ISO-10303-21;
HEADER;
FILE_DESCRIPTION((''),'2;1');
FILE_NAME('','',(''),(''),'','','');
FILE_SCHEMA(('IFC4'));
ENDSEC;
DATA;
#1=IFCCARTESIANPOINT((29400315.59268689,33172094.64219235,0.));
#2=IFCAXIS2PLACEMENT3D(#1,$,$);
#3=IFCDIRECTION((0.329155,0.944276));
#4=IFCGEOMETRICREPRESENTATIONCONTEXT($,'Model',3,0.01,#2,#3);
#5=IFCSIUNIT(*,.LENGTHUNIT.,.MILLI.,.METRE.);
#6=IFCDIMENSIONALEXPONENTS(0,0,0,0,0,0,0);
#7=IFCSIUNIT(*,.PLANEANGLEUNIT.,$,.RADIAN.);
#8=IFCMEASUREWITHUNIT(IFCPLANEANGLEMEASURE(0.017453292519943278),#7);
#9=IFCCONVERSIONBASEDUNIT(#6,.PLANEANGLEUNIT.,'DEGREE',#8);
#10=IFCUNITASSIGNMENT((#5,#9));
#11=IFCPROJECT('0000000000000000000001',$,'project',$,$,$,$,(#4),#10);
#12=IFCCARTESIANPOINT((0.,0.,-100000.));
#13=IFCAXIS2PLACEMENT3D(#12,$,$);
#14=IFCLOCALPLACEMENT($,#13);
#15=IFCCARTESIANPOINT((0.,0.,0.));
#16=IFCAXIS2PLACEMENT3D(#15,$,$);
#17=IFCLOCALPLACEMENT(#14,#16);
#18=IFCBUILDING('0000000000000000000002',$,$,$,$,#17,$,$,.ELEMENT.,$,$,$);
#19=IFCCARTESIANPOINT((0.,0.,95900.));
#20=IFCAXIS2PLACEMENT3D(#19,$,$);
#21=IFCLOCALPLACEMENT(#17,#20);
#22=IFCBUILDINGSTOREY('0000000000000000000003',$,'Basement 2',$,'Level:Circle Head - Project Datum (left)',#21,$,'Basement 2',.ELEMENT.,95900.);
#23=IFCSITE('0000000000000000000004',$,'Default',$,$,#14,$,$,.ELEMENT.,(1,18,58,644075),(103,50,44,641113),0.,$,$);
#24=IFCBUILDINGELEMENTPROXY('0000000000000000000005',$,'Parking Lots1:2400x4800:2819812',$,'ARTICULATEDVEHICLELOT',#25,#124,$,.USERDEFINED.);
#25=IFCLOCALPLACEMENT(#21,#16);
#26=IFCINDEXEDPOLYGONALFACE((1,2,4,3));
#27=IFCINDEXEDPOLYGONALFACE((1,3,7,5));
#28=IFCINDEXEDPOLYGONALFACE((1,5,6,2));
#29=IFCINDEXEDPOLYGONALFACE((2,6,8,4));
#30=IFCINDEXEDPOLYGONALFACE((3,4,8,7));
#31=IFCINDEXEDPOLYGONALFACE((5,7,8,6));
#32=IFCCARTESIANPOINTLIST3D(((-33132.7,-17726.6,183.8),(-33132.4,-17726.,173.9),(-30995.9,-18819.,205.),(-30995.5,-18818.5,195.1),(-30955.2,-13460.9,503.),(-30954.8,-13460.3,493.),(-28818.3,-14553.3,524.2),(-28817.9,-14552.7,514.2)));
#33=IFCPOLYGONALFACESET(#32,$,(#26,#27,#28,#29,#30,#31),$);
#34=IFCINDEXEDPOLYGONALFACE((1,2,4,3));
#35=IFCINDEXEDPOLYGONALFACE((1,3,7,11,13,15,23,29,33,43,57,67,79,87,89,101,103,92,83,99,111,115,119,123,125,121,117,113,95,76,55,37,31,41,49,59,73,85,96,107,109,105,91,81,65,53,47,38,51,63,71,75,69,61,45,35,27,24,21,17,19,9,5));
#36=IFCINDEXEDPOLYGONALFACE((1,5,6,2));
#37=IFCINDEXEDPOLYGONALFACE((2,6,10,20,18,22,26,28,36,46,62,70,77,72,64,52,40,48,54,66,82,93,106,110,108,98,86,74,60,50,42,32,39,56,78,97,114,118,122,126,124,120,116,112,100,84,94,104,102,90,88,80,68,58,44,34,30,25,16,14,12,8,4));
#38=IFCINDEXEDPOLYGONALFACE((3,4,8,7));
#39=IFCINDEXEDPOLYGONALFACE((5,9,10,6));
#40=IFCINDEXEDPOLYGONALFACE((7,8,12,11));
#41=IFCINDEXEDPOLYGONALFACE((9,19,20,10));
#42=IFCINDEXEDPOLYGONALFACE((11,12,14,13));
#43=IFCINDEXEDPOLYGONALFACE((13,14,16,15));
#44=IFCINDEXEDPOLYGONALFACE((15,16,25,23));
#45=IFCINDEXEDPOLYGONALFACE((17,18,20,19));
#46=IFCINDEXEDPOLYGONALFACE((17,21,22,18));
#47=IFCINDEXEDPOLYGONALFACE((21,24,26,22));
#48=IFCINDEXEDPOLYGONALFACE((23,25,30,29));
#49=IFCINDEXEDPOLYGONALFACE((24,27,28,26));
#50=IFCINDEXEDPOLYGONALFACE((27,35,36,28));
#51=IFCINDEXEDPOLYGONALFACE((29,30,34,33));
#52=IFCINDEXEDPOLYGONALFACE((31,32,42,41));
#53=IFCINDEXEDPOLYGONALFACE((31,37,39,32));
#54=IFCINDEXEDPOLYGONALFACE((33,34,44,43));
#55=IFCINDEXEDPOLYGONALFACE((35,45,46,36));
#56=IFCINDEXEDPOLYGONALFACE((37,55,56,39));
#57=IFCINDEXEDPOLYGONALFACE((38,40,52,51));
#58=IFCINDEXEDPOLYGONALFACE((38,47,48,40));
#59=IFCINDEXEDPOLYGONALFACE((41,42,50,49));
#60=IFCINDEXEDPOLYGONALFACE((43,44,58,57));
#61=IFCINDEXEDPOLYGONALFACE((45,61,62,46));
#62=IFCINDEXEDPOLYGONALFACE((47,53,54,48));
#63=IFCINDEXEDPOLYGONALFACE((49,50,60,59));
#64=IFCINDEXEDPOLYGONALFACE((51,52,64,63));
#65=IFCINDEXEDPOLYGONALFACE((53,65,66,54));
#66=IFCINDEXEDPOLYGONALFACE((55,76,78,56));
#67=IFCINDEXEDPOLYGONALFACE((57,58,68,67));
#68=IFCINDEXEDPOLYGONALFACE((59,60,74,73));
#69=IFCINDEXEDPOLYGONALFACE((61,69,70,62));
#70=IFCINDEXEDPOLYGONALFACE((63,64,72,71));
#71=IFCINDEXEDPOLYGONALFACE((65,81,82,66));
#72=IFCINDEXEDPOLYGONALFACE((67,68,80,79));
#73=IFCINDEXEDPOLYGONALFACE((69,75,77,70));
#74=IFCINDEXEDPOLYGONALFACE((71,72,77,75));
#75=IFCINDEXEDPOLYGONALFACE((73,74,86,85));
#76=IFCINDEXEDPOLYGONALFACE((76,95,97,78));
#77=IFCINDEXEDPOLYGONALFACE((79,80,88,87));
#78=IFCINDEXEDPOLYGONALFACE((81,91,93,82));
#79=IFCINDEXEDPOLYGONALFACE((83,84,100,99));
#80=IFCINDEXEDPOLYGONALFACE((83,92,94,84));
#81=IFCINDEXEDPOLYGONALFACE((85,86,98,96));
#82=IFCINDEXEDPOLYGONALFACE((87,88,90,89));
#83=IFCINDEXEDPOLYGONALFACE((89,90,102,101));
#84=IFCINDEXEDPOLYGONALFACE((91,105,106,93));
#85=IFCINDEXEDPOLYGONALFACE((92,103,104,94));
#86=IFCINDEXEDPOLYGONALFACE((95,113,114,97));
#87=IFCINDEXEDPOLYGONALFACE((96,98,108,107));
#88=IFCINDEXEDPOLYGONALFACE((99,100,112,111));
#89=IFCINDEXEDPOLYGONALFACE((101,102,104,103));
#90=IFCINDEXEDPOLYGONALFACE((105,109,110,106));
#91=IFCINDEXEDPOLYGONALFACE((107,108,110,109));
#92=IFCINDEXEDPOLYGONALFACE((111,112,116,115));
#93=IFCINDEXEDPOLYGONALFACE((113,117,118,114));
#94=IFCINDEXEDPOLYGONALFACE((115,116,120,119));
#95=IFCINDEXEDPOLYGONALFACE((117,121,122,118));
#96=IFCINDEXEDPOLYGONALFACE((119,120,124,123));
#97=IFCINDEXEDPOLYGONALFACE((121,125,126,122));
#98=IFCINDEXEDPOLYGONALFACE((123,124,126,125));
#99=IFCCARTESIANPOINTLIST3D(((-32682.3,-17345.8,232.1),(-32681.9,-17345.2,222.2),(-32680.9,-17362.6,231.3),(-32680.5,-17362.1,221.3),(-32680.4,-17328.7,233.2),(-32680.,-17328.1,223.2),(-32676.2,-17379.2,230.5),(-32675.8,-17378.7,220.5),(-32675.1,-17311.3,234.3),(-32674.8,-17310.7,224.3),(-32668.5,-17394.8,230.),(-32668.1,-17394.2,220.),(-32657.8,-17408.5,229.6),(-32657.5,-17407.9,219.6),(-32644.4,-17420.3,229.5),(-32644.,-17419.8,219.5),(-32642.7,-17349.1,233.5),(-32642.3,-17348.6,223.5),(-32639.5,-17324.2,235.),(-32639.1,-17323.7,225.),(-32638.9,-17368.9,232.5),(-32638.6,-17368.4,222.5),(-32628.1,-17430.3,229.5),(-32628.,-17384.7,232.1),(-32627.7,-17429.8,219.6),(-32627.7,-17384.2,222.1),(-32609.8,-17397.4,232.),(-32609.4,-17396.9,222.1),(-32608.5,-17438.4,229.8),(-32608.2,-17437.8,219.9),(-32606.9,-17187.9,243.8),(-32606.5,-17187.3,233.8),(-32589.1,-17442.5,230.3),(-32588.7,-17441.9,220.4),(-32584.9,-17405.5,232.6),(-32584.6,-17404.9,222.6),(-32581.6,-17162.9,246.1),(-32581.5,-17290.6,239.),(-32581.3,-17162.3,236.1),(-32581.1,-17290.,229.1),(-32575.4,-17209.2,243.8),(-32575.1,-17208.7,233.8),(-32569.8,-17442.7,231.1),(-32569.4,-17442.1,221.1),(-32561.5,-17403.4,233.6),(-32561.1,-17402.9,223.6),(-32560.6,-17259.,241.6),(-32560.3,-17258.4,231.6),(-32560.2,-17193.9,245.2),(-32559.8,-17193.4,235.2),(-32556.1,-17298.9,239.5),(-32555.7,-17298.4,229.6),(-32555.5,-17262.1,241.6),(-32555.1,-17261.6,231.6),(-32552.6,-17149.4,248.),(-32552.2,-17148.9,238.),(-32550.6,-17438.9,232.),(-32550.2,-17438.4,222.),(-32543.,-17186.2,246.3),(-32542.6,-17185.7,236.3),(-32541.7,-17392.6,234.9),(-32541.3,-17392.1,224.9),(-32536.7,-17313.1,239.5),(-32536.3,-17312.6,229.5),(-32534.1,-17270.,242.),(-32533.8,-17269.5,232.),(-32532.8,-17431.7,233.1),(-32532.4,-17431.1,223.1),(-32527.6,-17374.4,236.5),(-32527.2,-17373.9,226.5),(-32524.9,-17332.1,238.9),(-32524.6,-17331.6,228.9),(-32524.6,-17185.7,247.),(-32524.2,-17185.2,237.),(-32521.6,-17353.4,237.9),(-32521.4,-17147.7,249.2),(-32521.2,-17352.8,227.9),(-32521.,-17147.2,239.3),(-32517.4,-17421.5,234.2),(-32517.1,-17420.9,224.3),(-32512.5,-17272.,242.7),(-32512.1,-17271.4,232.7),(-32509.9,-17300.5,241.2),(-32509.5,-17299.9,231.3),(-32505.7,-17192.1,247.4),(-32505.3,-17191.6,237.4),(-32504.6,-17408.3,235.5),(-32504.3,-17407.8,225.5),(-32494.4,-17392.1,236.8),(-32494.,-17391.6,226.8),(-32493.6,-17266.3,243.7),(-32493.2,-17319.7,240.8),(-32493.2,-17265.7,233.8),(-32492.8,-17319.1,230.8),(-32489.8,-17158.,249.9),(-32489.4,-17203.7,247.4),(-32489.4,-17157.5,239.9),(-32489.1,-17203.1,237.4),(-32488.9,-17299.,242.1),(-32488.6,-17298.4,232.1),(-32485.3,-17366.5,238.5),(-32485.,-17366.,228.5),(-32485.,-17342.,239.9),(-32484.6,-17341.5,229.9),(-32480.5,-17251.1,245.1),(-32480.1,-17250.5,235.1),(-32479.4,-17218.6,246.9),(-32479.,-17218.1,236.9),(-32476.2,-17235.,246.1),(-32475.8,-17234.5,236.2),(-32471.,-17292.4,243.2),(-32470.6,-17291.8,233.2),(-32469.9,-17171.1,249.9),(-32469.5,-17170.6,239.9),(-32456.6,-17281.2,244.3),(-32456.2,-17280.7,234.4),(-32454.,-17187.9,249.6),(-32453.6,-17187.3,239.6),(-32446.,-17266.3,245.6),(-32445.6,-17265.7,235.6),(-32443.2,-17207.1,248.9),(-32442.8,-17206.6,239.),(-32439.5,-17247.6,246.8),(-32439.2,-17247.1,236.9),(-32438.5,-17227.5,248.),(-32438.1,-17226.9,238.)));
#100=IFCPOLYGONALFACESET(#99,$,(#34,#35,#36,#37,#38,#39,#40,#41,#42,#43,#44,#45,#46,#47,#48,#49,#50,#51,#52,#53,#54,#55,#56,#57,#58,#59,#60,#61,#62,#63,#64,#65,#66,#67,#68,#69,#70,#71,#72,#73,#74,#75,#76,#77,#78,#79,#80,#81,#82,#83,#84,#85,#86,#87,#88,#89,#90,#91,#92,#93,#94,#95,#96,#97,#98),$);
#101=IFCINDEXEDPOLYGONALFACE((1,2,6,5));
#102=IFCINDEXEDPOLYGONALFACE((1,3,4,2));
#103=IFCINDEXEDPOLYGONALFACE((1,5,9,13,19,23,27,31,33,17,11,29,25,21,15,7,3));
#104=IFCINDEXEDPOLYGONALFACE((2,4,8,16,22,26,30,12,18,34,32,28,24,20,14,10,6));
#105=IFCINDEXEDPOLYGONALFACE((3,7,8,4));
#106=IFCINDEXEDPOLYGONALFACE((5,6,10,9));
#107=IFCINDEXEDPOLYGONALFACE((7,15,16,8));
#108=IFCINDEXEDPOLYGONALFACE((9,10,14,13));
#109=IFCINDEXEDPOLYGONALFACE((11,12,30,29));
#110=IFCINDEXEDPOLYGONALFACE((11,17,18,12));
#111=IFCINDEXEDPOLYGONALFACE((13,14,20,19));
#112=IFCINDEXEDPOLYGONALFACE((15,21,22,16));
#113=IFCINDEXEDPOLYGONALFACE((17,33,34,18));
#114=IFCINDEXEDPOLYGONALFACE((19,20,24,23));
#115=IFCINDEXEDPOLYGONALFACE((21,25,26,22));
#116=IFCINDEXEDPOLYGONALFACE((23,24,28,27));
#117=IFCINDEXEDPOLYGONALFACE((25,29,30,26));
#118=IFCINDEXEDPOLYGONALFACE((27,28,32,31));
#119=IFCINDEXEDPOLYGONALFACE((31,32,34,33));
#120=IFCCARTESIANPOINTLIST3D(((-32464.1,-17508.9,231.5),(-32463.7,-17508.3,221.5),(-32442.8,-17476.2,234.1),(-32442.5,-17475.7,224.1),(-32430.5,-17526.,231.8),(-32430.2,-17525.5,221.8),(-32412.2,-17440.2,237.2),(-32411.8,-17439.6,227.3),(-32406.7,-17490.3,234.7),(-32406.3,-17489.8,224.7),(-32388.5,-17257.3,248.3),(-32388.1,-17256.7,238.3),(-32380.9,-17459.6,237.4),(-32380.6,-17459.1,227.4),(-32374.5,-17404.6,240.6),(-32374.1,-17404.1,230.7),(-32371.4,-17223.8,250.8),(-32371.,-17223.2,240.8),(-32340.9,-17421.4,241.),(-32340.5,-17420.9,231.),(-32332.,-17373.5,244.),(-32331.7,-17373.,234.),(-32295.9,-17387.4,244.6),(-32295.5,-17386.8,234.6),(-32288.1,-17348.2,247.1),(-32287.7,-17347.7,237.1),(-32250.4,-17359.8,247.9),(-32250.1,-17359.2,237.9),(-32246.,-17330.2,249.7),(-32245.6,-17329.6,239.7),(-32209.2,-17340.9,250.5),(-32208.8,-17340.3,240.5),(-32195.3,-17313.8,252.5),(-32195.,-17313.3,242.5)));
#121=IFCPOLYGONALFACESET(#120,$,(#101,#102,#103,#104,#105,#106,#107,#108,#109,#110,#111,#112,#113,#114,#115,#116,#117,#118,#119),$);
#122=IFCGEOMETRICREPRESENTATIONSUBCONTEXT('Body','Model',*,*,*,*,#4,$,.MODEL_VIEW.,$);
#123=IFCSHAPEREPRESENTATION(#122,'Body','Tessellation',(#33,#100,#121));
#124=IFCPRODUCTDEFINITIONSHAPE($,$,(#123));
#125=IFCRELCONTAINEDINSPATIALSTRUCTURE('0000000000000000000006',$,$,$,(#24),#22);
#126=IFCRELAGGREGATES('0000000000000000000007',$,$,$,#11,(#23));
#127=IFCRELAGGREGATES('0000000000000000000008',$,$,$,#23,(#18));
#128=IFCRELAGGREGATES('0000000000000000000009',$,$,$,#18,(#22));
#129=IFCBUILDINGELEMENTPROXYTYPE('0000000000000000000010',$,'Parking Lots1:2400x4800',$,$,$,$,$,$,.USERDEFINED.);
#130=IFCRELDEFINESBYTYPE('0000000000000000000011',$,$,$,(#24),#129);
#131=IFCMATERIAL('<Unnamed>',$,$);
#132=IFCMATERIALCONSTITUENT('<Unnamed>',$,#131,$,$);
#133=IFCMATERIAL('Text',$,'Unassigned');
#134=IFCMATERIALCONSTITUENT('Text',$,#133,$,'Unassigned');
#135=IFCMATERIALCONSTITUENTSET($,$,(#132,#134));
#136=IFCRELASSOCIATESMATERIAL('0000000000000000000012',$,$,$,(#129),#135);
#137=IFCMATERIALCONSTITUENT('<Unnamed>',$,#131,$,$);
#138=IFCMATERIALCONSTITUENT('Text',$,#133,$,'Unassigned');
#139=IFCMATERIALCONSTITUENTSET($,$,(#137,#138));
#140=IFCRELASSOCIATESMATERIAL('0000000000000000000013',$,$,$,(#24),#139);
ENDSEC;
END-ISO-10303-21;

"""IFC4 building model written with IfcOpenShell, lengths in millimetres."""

from ifc_helpers import new_model, entity, si_unit, converted_unit, direction, frame, origin, place, context, subcontext, project, spatial, indexed_curve, outline, extrude, source, transform, mapped, material, constituent, constituent_set, type_object, type_shapes, element, save


model = new_model("IFC4")

# Units and contexts
model_context = context("Model", 3, precision=0.01, world=frame((29400315.59268689, 33172094.64219235, 0.0)), true_north=direction((0.329155, 0.944276)))
body_context = subcontext(model_context, "Body", "Model", "MODEL_VIEW")
ifc_project = project(units=[si_unit("LENGTHUNIT", "METRE", prefix="MILLI"), converted_unit("PLANEANGLEUNIT", "DEGREE", entity("IfcPlaneAngleMeasure", 0.017453292519943278), si_unit("PLANEANGLEUNIT", "RADIAN"), dimensions=[0, 0, 0, 0, 0, 0, 0])], contexts=[model_context])

# Site, building, storey
site_placement = place(None, frame((0.0, 0.0, -100000.0)))
site = spatial("IfcSite", under=ifc_project, at=site_placement, Name="Default", CompositionType="ELEMENT", RefLatitude=(1, 18, 58, 644075), RefLongitude=(103, 50, 44, 641113), RefElevation=0.0)
building_placement = place(site_placement, origin())
building = spatial("IfcBuilding", under=site, at=building_placement, CompositionType="ELEMENT")
storey_placement = place(building_placement, frame((0.0, 0.0, 95900.0)))
storey = spatial("IfcBuildingStorey", under=building, at=storey_placement, Name="Basement 2", ObjectType="Level:Circle Head - Project Datum (left)", LongName="Basement 2", CompositionType="ELEMENT", Elevation=95900.0)

# Shared definitions
ifc_material_1 = material(Name="<Unnamed>")

# Building element proxy
ifc_material_2 = material(Name="Text", Category="Unassigned")
ifc_constituent_1 = constituent(ifc_material_1, Name="<Unnamed>")
ifc_constituent_2 = constituent(ifc_material_2, Name="Text", Category="Unassigned")
ifc_constituent_set_1 = constituent_set(constituents=[ifc_constituent_1, ifc_constituent_2])
ifc_constituent_3 = constituent(ifc_material_1, Name="<Unnamed>")
ifc_constituent_4 = constituent(ifc_material_2, Name="Text", Category="Unassigned")
ifc_constituent_set_2 = constituent_set(constituents=[ifc_constituent_3, ifc_constituent_4])
building_element_proxy_type_1 = type_object("IfcBuildingElementProxyType", Name="Parking Lots1:2400x4800", PredefinedType="USERDEFINED", material=ifc_constituent_set_2)
shared_shape_1 = source(origin(), body_context, "Body", "SweptSolid", [
    extrude(outline(indexed_curve([(-1200.0, -2400.0), (1200.0, -2400.0), (1200.0, 2400.0), (-1200.0, 2400.0), (-1200.0, -2400.0)], self_intersect=False)), frame((1200.0, -2400.0, 0.0), z_axis=(0.0, 0.0, 1.0), x_axis=(-1.0, 0.0, 0.0)), (0.0, 0.0, 1.0), 10.0),
    extrude(outline(indexed_curve([(41.2, -119.5), (59.4, -119.5), (76.4, -116.4), (92.1, -110.3), (106.7, -101.0), (119.4, -89.1), (129.4, -75.0), (136.9, -58.7), (141.8, -40.2), (143.8, -19.2), (142.2, 0.6), (136.7, 19.2), (127.6, 36.5), (115.5, 51.5), (101.3, 63.2), (84.9, 71.7), (66.4, 76.9), (39.2, 78.2), (15.6, 71.5), (-3.5, 57.2), (-17.0, 35.7), (-24.5, 55.3), (-36.1, 70.5), (-50.9, 81.2), (-68.4, 87.0), (-88.1, 87.8), (-107.7, 83.0), (-125.9, 72.6), (-141.2, 56.8), (-152.7, 36.8), (-159.5, 13.9), (-160.2, -19.4), (-149.6, -48.7), (-128.2, -72.7), (-96.9, -89.6), (-85.6, -53.4), (-104.7, -43.2), (-117.0, -28.9), (-122.8, -11.5), (-122.2, 8.5), (-115.8, 27.4), (-104.4, 41.3), (-89.5, 49.1), (-72.9, 49.6), (-54.6, 41.4), (-43.6, 24.9), (-39.2, 3.6), (-40.6, -19.0), (-42.1, -24.9), (-5.8, -35.8), (-5.1, -9.0), (2.9, 13.6), (17.7, 30.3), (37.1, 39.7), (59.0, 40.0), (80.6, 31.7), (96.7, 15.8), (105.4, -6.0), (104.9, -32.2), (98.0, -53.3), (86.0, -68.3), (68.1, -77.6), (43.3, -81.6), (41.2, -119.5)], self_intersect=False)), frame((329.1, -4158.0, 10.0), z_axis=(0.0, 0.0, 1.0), x_axis=(0.178774, -0.98389, 0.0)), (0.0, 0.0, 1.0), 10.0),
    extrude(outline(indexed_curve([(-101.8, -99.3), (-101.8, -137.0), (96.0, -137.0), (96.0, -106.5), (67.8, -70.9), (39.9, -25.5), (15.2, 25.4), (-3.1, 77.8), (-12.1, 116.9), (-17.1, 159.7), (-54.7, 159.7), (-50.7, 120.8), (-39.8, 74.7), (-22.3, 25.8), (1.3, -21.4), (29.0, -64.0), (58.3, -99.3), (-101.8, -99.3)], self_intersect=False)), frame((551.4, -4140.3, 10.0), z_axis=(0.0, 0.0, -1.0), x_axis=(1.0, 0.0, 0.0)), (0.0, 0.0, -1.0), 10.0),
])
type_shapes(building_element_proxy_type_1, [shared_shape_1])
proxy_1_placement = place(storey_placement, frame((-30954.8, -13460.3, 493.0), z_axis=(-0.038113, -0.055189, 0.997748), x_axis=(0.890359, -0.455173, 0.008834)))
element("IfcBuildingElementProxy", 1, at=proxy_1_placement, inside=storey, type_object=building_element_proxy_type_1, material=ifc_constituent_set_1, Name="Parking Lots1:2400x4800:2819812", ObjectType="ARTICULATEDVEHICLELOT", PredefinedType="USERDEFINED", context=body_context, shape_type="MappedRepresentation", body=[
    mapped(shared_shape_1, transform((0.0, 0.0, 0.0), scale=1.0)),
])

save(model, "model.ifc")
